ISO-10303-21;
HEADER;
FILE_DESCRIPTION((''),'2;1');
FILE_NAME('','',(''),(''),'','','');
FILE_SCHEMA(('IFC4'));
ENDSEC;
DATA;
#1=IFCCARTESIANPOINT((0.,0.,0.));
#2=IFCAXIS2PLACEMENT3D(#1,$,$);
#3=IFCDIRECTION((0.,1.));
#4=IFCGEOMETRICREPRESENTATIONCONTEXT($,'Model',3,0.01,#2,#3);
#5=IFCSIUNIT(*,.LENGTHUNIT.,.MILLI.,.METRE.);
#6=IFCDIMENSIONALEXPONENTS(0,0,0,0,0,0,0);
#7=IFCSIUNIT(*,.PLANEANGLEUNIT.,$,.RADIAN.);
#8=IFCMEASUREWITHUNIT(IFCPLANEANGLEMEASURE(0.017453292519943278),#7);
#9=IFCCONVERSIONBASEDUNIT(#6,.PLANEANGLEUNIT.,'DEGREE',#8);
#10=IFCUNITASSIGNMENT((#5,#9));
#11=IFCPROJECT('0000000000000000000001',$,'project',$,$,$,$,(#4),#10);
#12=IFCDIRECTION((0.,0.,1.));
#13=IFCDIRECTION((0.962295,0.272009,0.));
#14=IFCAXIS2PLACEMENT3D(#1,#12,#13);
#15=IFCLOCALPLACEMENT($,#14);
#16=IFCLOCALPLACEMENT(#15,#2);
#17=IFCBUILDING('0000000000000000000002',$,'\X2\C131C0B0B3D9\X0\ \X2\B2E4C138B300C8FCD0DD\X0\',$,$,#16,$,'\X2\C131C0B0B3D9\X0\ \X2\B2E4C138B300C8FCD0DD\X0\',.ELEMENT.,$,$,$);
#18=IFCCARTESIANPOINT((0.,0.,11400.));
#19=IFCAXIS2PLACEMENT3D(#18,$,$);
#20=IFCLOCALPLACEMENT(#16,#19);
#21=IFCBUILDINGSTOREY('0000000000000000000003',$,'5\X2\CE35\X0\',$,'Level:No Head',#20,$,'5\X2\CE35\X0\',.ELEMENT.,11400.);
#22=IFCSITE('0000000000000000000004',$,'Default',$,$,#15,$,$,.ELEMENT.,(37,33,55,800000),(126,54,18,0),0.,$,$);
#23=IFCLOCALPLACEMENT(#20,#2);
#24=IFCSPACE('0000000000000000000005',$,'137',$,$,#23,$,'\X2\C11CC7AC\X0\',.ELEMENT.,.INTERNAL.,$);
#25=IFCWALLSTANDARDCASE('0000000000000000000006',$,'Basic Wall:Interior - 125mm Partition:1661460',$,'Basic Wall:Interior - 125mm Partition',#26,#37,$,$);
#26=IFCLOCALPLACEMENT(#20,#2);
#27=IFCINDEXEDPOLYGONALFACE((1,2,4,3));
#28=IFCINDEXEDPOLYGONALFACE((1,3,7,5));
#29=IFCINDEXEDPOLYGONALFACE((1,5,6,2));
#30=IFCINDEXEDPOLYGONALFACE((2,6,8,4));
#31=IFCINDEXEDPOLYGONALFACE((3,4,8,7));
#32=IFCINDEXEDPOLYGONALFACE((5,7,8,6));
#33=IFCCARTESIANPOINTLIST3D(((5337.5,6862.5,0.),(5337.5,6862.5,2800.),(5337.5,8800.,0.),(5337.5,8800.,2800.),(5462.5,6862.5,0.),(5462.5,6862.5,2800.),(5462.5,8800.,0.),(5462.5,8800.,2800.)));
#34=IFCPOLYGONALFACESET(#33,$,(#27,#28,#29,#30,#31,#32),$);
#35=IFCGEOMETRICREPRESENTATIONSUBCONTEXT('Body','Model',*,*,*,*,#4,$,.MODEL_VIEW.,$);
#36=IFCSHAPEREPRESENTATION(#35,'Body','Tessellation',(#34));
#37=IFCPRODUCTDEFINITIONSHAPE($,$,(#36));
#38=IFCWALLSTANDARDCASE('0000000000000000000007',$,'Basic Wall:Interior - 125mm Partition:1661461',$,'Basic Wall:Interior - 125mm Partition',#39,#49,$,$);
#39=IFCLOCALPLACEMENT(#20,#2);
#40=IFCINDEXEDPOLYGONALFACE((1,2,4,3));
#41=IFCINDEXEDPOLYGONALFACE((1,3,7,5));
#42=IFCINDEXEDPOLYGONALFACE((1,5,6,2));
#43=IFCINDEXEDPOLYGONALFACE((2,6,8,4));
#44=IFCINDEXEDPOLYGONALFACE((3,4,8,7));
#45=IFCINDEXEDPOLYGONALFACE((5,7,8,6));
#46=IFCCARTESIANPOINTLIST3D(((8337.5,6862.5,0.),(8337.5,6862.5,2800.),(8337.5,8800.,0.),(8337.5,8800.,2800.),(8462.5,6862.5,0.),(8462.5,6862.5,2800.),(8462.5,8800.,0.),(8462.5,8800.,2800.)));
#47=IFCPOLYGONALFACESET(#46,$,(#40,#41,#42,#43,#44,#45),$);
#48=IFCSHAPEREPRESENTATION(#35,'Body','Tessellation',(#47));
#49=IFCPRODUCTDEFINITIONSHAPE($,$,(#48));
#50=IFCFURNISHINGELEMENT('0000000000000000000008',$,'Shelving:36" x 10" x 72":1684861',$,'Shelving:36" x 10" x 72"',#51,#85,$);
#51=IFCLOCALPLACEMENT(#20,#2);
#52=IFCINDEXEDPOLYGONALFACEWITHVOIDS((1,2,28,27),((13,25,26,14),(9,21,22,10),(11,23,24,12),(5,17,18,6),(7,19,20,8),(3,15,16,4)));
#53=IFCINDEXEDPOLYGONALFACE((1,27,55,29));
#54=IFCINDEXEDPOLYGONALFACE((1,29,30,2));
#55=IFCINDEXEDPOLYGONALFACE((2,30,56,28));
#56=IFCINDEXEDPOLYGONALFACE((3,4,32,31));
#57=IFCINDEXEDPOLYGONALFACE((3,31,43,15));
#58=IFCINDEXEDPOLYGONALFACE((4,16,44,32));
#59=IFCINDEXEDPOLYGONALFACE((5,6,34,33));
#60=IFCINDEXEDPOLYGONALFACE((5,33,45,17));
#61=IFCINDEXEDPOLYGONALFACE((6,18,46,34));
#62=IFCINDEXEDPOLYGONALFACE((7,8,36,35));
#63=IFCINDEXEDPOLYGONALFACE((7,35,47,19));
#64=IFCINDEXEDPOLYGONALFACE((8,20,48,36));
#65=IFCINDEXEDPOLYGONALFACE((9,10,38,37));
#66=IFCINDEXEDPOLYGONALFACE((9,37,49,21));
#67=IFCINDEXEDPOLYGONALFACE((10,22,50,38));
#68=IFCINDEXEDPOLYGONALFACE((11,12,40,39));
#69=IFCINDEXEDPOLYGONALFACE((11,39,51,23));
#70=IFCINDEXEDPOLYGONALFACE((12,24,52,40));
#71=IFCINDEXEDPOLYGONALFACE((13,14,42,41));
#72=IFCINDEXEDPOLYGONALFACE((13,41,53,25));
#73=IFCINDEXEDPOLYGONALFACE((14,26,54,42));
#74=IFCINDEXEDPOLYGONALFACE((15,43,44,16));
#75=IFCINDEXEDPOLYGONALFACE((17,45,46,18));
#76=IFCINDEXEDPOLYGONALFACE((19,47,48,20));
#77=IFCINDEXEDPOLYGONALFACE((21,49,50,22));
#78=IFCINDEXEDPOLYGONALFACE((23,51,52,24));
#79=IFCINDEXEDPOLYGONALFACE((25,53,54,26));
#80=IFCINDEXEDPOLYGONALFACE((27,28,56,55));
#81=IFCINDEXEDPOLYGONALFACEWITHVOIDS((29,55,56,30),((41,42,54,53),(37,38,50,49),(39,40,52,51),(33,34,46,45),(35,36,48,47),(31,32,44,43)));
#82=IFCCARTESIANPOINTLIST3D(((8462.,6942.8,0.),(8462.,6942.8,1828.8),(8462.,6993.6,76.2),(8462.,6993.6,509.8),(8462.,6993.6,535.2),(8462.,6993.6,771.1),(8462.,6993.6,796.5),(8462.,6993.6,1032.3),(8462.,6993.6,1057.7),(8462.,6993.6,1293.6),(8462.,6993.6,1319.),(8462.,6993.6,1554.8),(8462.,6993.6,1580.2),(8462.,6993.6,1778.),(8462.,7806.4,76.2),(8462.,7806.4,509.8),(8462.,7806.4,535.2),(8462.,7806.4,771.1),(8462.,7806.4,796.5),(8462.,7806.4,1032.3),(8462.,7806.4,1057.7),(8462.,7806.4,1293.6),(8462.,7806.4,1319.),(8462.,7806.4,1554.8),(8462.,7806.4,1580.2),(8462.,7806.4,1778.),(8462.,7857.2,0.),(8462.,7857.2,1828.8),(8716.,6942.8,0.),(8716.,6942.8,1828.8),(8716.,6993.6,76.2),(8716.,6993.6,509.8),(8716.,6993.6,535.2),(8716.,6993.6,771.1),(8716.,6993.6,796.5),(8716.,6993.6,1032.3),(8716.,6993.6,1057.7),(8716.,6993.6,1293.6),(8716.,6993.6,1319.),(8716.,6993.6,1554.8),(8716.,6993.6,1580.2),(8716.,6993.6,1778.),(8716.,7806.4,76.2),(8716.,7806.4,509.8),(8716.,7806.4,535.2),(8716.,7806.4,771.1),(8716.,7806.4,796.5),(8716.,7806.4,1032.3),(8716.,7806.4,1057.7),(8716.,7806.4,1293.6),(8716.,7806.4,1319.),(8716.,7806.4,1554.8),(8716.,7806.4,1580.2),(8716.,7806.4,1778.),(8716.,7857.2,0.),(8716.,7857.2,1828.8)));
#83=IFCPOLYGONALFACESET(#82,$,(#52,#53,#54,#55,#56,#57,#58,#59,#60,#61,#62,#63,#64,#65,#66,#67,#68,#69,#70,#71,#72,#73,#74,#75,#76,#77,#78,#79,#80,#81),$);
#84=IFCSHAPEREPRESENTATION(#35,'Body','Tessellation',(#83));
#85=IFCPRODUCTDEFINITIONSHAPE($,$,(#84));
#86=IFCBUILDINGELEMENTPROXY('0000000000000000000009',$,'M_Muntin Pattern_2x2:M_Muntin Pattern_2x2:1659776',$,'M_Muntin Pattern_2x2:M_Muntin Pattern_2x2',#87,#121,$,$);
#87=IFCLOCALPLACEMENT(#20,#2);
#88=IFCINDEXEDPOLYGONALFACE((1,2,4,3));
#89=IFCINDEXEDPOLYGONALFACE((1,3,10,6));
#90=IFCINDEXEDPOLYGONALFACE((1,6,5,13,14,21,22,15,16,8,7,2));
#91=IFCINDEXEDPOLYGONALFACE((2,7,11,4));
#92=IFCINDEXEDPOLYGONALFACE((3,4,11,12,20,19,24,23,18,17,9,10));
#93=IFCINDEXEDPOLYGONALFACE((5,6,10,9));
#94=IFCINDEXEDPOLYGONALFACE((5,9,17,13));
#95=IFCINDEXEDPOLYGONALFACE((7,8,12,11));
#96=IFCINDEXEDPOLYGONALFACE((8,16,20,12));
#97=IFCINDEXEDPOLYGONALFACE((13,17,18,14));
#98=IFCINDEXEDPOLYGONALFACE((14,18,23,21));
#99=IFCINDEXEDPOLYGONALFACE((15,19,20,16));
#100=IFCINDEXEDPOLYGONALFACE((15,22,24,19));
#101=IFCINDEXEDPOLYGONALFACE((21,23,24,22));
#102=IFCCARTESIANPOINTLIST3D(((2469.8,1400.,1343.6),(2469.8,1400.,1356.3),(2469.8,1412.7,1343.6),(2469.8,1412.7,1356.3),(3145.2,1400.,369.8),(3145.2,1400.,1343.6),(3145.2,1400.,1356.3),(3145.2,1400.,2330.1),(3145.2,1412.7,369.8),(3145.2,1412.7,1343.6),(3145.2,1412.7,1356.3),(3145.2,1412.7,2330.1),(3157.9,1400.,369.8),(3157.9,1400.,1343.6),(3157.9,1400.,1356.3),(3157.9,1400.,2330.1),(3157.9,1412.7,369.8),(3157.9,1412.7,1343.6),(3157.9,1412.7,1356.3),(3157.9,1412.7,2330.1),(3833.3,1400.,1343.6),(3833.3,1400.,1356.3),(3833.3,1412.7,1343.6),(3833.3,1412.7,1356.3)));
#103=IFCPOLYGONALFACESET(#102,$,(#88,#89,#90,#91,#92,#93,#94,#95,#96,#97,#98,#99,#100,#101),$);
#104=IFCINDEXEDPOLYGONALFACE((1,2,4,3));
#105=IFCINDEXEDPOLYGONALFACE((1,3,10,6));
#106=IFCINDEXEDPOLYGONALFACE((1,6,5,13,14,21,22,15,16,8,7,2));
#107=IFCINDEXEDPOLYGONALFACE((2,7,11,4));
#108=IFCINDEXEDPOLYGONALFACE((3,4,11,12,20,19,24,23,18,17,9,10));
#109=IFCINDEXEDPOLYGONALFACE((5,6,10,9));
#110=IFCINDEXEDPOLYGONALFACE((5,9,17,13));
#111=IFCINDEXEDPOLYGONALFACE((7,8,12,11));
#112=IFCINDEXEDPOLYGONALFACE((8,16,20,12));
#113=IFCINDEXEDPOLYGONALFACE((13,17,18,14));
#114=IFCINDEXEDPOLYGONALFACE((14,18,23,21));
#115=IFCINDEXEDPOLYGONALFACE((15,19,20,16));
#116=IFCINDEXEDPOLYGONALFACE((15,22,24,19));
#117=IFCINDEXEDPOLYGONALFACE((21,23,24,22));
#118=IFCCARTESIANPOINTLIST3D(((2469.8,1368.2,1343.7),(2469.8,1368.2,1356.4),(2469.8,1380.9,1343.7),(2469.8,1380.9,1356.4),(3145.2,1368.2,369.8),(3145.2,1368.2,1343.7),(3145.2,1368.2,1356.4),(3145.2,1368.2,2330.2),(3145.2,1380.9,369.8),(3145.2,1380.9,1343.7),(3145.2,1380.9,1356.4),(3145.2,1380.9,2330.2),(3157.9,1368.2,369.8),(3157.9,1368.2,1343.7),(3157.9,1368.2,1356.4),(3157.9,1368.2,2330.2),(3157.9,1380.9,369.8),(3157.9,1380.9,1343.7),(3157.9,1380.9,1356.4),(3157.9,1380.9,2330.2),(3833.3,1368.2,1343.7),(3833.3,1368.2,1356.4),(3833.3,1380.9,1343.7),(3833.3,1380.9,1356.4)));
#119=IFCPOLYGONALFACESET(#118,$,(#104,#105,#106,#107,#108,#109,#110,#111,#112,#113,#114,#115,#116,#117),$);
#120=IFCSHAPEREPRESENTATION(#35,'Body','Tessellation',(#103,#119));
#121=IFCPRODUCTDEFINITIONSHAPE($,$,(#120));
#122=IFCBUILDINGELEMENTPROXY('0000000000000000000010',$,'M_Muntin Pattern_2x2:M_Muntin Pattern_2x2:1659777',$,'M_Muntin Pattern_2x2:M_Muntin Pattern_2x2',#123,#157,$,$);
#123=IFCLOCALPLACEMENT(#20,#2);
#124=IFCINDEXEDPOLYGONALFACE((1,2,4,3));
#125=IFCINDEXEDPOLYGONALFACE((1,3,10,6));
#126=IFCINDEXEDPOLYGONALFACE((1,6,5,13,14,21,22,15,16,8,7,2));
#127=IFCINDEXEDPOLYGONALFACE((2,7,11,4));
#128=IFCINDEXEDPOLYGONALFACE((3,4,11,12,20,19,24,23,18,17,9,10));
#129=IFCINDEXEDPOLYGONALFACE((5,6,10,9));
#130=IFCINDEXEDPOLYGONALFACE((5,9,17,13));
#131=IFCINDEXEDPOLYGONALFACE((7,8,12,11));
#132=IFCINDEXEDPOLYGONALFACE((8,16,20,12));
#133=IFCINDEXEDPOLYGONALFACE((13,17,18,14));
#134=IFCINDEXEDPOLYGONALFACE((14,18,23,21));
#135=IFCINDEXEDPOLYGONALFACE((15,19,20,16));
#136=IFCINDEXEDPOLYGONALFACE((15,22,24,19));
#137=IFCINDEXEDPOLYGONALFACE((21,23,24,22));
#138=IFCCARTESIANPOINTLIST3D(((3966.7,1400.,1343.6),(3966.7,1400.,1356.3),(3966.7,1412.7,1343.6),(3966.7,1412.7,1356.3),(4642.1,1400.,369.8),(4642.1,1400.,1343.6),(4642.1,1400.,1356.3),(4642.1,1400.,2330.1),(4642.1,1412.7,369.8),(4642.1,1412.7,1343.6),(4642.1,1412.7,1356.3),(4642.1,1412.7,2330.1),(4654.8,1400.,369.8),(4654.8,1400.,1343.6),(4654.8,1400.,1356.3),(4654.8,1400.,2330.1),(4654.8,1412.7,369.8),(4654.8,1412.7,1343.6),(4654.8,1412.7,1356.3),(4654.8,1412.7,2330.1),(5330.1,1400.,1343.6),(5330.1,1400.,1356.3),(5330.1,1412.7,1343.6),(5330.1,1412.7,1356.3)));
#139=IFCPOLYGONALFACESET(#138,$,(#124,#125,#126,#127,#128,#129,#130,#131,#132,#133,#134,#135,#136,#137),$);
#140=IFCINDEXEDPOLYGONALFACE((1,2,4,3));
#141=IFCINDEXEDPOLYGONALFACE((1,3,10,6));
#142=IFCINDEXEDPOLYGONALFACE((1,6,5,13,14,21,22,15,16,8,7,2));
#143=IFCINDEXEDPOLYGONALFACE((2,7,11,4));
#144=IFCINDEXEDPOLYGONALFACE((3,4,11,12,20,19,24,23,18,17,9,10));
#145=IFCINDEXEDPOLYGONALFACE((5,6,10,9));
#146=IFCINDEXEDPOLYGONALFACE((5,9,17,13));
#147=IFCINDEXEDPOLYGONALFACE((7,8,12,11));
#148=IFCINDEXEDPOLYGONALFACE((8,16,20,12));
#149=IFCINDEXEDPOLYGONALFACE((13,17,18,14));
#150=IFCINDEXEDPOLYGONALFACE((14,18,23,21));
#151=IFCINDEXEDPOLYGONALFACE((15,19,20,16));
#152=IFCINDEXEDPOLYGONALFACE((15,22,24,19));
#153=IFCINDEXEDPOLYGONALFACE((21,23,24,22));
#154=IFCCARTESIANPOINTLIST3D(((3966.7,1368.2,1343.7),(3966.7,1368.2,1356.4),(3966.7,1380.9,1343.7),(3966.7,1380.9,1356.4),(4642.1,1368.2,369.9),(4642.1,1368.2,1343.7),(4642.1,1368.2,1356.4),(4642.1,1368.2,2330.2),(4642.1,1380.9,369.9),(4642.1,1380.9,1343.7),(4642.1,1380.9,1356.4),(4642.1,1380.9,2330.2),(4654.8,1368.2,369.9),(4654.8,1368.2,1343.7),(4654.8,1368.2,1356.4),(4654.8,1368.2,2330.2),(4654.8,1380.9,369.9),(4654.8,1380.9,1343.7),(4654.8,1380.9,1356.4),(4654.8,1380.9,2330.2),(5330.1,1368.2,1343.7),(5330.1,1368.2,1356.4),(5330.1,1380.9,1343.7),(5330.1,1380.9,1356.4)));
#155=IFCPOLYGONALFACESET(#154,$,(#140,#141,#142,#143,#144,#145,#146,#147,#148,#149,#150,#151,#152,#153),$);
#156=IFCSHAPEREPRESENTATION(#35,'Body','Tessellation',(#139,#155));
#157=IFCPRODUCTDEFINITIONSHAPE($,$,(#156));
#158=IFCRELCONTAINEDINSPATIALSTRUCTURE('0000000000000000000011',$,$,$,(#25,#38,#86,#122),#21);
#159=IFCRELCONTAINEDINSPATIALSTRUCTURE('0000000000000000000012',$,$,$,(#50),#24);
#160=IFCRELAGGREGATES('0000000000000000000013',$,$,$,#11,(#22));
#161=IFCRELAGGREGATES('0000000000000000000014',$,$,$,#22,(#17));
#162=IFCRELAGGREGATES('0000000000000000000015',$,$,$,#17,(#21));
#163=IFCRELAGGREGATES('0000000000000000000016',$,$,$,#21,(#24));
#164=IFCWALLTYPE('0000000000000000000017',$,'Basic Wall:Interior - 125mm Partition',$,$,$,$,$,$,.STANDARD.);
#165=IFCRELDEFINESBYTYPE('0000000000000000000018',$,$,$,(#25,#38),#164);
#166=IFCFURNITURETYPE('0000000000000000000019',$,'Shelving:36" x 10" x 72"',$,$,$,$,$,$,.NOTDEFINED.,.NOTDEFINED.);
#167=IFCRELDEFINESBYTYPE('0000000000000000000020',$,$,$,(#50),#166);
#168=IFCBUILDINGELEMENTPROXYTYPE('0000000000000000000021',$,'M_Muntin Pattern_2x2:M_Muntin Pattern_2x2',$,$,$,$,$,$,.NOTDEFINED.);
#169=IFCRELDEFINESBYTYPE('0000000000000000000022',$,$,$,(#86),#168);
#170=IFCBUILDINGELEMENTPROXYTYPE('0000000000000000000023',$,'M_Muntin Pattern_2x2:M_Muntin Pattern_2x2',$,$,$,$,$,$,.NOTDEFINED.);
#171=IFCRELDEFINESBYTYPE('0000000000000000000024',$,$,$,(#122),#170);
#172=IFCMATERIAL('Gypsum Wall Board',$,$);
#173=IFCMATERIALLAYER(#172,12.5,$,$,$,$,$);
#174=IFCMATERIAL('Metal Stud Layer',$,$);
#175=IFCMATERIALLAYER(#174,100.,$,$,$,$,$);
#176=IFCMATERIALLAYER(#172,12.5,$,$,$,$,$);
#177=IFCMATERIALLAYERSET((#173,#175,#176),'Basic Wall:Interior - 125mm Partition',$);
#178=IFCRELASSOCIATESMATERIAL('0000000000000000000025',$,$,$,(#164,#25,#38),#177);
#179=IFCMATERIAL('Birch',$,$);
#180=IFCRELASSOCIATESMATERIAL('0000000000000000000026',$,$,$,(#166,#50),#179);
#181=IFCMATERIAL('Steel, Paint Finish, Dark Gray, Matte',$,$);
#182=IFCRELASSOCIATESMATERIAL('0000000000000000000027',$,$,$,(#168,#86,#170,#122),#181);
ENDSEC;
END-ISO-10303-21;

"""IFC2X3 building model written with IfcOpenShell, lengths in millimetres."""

from ifc_helpers import new_model, entity, si_unit, converted_unit, direction, frame, frame_2d, origin, place, context, subcontext, project, spatial, polyline, rectangle, outline, extrude, source, transform, mapped, material, layer, layer_set, layer_usage, type_object, type_shapes, element, save


model = new_model("IFC2X3")

# Units and contexts
model_context = context("Model", 3, precision=0.01, world=origin(), true_north=direction((0.0, 1.0)))
body_context = subcontext(model_context, "Body", "Model", "MODEL_VIEW")
ifc_project = project(units=[si_unit("LENGTHUNIT", "METRE", prefix="MILLI"), converted_unit("PLANEANGLEUNIT", "DEGREE", entity("IfcPlaneAngleMeasure", 0.017453292519943278), si_unit("PLANEANGLEUNIT", "RADIAN"), dimensions=[0, 0, 0, 0, 0, 0, 0])], contexts=[model_context])

# Site, building, storey
site_placement = place(None, frame((0.0, 0.0, 0.0), z_axis=(0.0, 0.0, 1.0), x_axis=(0.962295, 0.272009, 0.0)))
site = spatial("IfcSite", under=ifc_project, at=site_placement, Name="Default", CompositionType="ELEMENT", RefLatitude=(37, 33, 55, 800000), RefLongitude=(126, 54, 18, 0), RefElevation=0.0)
building_placement = place(site_placement, origin())
building = spatial("IfcBuilding", under=site, at=building_placement, Name="성산동 다세대주택", LongName="성산동 다세대주택", CompositionType="ELEMENT")
storey_placement = place(building_placement, frame((0.0, 0.0, 11400.0)))
storey = spatial("IfcBuildingStorey", under=building, at=storey_placement, Name="5층", ObjectType="Level:No Head", LongName="5층", CompositionType="ELEMENT", Elevation=11400.0)

# Walls
ifc_material_1 = material(Name="Gypsum Wall Board")
ifc_layer_1 = layer(ifc_material_1, 12.5)
ifc_material_2 = material(Name="Metal Stud Layer")
ifc_layer_2 = layer(ifc_material_2, 100.0)
ifc_layer_3 = layer(ifc_material_1, 12.5)
ifc_layer_set = layer_set([ifc_layer_1, ifc_layer_2, ifc_layer_3], Name="Basic Wall:Interior - 125mm Partition")
ifc_layer_usage_1 = layer_usage(ifc_layer_set, "AXIS2", "NEGATIVE", 62.5)
wall_type = type_object("IfcWallType", Name="Basic Wall:Interior - 125mm Partition", PredefinedType="STANDARD", material=ifc_layer_set)
wall_1_placement = place(storey_placement, frame((5400.0, 6862.5, 0.0), z_axis=(0.0, 0.0, 1.0), x_axis=(0.0, 1.0, 0.0)))
element("IfcWallStandardCase", 1, at=wall_1_placement, inside=storey, type_object=wall_type, material=ifc_layer_usage_1, Name="Basic Wall:Interior - 125mm Partition:1661460", ObjectType="Basic Wall:Interior - 125mm Partition", context=body_context, shape_type="SweptSolid", body=[
    extrude(rectangle(XDim=1937.5, YDim=125.0, at=frame_2d((968.7, 0.0), x_axis=(-1.0, 0.0))), origin(), (0.0, 0.0, 1.0), 2800.0),
])
ifc_layer_usage_2 = layer_usage(ifc_layer_set, "AXIS2", "NEGATIVE", 62.5)
wall_2_placement = place(storey_placement, frame((8400.0, 6862.5, 0.0), z_axis=(0.0, 0.0, 1.0), x_axis=(0.0, 1.0, 0.0)))
element("IfcWallStandardCase", 2, at=wall_2_placement, inside=storey, type_object=wall_type, material=ifc_layer_usage_2, Name="Basic Wall:Interior - 125mm Partition:1661461", ObjectType="Basic Wall:Interior - 125mm Partition", context=body_context, shape_type="SweptSolid", body=[
    extrude(rectangle(XDim=1937.5, YDim=125.0, at=frame_2d((968.7, 0.0), x_axis=(-1.0, 0.0))), origin(), (0.0, 0.0, 1.0), 2800.0),
])

# Shared definitions
space_1_placement = place(storey_placement, origin())
space_1 = spatial("IfcSpace", under=storey, at=space_1_placement, Name="137", LongName="서재", CompositionType="ELEMENT", InteriorOrExteriorSpace="INTERNAL")

# Furnishing element
ifc_material_3 = material(Name="Birch")
furniture_type_1 = type_object("IfcFurnitureType", Name="Shelving:36\" x 10\" x 72\"", AssemblyPlace="NOTDEFINED", material=ifc_material_3)
shared_shape_1 = source(origin(), body_context, "Body", "SweptSolid", [
    extrude(outline(polyline([(-457.2, -914.4), (457.2, -914.4), (457.2, 914.4), (-457.2, 914.4), (-457.2, -914.4)]), holes=[polyline([(-406.4, 863.6), (406.4, 863.6), (406.4, 665.8), (-406.4, 665.8), (-406.4, 863.6)]), polyline([(-406.4, -838.2), (-406.4, -404.6), (406.4, -404.6), (406.4, -838.2), (-406.4, -838.2)]), polyline([(406.4, 143.3), (-406.4, 143.3), (-406.4, 379.2), (406.4, 379.2), (406.4, 143.3)]), polyline([(-406.4, 640.4), (406.4, 640.4), (406.4, 404.6), (-406.4, 404.6), (-406.4, 640.4)]), polyline([(-406.4, 117.9), (406.4, 117.9), (406.4, -117.9), (-406.4, -117.9), (-406.4, 117.9)]), polyline([(-406.4, -143.3), (406.4, -143.3), (406.4, -379.2), (-406.4, -379.2), (-406.4, -143.3)])]), frame((0.0, -431.8, 914.4), z_axis=(0.0, 1.0, 0.0), x_axis=(-1.0, 0.0, 0.0)), (0.0, 0.0, 1.0), 254.0),
])
type_shapes(furniture_type_1, [shared_shape_1])
furnishing_1_placement = place(space_1_placement, frame((8284.2, 7400.0, 0.0), z_axis=(0.0, 0.0, 1.0), x_axis=(0.0, 1.0, 0.0)))
element("IfcFurnishingElement", 3, at=furnishing_1_placement, inside=space_1, type_object=furniture_type_1, material=ifc_material_3, Name="Shelving:36\" x 10\" x 72\":1684861", ObjectType="Shelving:36\" x 10\" x 72\"", context=body_context, shape_type="MappedRepresentation", body=[
    mapped(shared_shape_1, transform((0.0, 0.0, 0.0), scale=1.0)),
])

# Building element proxies
ifc_material_4 = material(Name="Steel, Paint Finish, Dark Gray, Matte")
building_element_proxy_type_1 = type_object("IfcBuildingElementProxyType", Name="M_Muntin Pattern_2x2:M_Muntin Pattern_2x2", PredefinedType="NOTDEFINED", material=ifc_material_4)
shared_shape_2 = source(origin(), body_context, "Body", "SweptSolid", [
    extrude(outline(polyline([(6.4, -6.4), (980.1, -6.4), (980.1, 6.3), (6.4, 6.3), (6.4, 681.7), (-6.3, 681.7), (-6.3, 6.3), (-980.2, 6.3), (-980.2, -6.4), (-6.3, -6.4), (-6.3, -681.7), (6.4, -681.7), (6.4, -6.4)])), frame((0.0, 9.5, 980.1), z_axis=(0.0, 1.0, 0.0), x_axis=(0.0, 0.0, 1.0)), (0.0, 0.0, 1.0), 12.7),
    extrude(outline(polyline([(6.4, -6.4), (980.2, -6.4), (980.2, 6.3), (6.4, 6.3), (6.4, 681.7), (-6.3, 681.7), (-6.3, 6.3), (-980.2, 6.3), (-980.2, -6.4), (-6.3, -6.4), (-6.3, -681.7), (6.4, -681.7), (6.4, -6.4)])), frame((0.0, -22.2, 980.2), z_axis=(0.0, 1.0, 0.0), x_axis=(0.0, 0.0, 1.0)), (0.0, 0.0, 1.0), 12.7),
])
type_shapes(building_element_proxy_type_1, [shared_shape_2])
proxy_1_placement = place(storey_placement, frame((3151.6, 1390.5, 369.8)))
element("IfcBuildingElementProxy", 4, at=proxy_1_placement, inside=storey, type_object=building_element_proxy_type_1, material=ifc_material_4, Name="M_Muntin Pattern_2x2:M_Muntin Pattern_2x2:1659776", ObjectType="M_Muntin Pattern_2x2:M_Muntin Pattern_2x2", context=body_context, shape_type="MappedRepresentation", body=[
    mapped(shared_shape_2, transform((0.0, 0.0, 0.0), scale=1.0)),
])
building_element_proxy_type_2 = type_object("IfcBuildingElementProxyType", Name="M_Muntin Pattern_2x2:M_Muntin Pattern_2x2", PredefinedType="NOTDEFINED", material=ifc_material_4)
shared_shape_3 = source(origin(), body_context, "Body", "SweptSolid", [
    extrude(outline(polyline([(6.4, -6.4), (980.1, -6.4), (980.1, 6.3), (6.4, 6.3), (6.4, 681.7), (-6.3, 681.7), (-6.3, 6.3), (-980.2, 6.3), (-980.2, -6.4), (-6.3, -6.4), (-6.3, -681.7), (6.4, -681.7), (6.4, -6.4)])), frame((0.0, -22.2, 980.1), z_axis=(0.0, 1.0, 0.0), x_axis=(0.0, 0.0, 1.0)), (0.0, 0.0, 1.0), 12.7),
    extrude(outline(polyline([(6.4, -6.4), (980.2, -6.4), (980.2, 6.3), (6.4, 6.3), (6.4, 681.7), (-6.3, 681.7), (-6.3, 6.3), (-980.2, 6.3), (-980.2, -6.4), (-6.3, -6.4), (-6.3, -681.7), (6.4, -681.7), (6.4, -6.4)])), frame((0.0, 9.5, 980.2), z_axis=(0.0, 1.0, 0.0), x_axis=(0.0, 0.0, 1.0)), (0.0, 0.0, 1.0), 12.7),
])
type_shapes(building_element_proxy_type_2, [shared_shape_3])
proxy_2_placement = place(storey_placement, frame((4648.4, 1390.5, 369.9), z_axis=(0.0, 0.0, 1.0), x_axis=(-1.0, 0.0, 0.0)))
element("IfcBuildingElementProxy", 5, at=proxy_2_placement, inside=storey, type_object=building_element_proxy_type_2, material=ifc_material_4, Name="M_Muntin Pattern_2x2:M_Muntin Pattern_2x2:1659777", ObjectType="M_Muntin Pattern_2x2:M_Muntin Pattern_2x2", context=body_context, shape_type="MappedRepresentation", body=[
    mapped(shared_shape_3, transform((0.0, 0.0, 0.0), scale=1.0)),
])

save(model, "model.ifc")
